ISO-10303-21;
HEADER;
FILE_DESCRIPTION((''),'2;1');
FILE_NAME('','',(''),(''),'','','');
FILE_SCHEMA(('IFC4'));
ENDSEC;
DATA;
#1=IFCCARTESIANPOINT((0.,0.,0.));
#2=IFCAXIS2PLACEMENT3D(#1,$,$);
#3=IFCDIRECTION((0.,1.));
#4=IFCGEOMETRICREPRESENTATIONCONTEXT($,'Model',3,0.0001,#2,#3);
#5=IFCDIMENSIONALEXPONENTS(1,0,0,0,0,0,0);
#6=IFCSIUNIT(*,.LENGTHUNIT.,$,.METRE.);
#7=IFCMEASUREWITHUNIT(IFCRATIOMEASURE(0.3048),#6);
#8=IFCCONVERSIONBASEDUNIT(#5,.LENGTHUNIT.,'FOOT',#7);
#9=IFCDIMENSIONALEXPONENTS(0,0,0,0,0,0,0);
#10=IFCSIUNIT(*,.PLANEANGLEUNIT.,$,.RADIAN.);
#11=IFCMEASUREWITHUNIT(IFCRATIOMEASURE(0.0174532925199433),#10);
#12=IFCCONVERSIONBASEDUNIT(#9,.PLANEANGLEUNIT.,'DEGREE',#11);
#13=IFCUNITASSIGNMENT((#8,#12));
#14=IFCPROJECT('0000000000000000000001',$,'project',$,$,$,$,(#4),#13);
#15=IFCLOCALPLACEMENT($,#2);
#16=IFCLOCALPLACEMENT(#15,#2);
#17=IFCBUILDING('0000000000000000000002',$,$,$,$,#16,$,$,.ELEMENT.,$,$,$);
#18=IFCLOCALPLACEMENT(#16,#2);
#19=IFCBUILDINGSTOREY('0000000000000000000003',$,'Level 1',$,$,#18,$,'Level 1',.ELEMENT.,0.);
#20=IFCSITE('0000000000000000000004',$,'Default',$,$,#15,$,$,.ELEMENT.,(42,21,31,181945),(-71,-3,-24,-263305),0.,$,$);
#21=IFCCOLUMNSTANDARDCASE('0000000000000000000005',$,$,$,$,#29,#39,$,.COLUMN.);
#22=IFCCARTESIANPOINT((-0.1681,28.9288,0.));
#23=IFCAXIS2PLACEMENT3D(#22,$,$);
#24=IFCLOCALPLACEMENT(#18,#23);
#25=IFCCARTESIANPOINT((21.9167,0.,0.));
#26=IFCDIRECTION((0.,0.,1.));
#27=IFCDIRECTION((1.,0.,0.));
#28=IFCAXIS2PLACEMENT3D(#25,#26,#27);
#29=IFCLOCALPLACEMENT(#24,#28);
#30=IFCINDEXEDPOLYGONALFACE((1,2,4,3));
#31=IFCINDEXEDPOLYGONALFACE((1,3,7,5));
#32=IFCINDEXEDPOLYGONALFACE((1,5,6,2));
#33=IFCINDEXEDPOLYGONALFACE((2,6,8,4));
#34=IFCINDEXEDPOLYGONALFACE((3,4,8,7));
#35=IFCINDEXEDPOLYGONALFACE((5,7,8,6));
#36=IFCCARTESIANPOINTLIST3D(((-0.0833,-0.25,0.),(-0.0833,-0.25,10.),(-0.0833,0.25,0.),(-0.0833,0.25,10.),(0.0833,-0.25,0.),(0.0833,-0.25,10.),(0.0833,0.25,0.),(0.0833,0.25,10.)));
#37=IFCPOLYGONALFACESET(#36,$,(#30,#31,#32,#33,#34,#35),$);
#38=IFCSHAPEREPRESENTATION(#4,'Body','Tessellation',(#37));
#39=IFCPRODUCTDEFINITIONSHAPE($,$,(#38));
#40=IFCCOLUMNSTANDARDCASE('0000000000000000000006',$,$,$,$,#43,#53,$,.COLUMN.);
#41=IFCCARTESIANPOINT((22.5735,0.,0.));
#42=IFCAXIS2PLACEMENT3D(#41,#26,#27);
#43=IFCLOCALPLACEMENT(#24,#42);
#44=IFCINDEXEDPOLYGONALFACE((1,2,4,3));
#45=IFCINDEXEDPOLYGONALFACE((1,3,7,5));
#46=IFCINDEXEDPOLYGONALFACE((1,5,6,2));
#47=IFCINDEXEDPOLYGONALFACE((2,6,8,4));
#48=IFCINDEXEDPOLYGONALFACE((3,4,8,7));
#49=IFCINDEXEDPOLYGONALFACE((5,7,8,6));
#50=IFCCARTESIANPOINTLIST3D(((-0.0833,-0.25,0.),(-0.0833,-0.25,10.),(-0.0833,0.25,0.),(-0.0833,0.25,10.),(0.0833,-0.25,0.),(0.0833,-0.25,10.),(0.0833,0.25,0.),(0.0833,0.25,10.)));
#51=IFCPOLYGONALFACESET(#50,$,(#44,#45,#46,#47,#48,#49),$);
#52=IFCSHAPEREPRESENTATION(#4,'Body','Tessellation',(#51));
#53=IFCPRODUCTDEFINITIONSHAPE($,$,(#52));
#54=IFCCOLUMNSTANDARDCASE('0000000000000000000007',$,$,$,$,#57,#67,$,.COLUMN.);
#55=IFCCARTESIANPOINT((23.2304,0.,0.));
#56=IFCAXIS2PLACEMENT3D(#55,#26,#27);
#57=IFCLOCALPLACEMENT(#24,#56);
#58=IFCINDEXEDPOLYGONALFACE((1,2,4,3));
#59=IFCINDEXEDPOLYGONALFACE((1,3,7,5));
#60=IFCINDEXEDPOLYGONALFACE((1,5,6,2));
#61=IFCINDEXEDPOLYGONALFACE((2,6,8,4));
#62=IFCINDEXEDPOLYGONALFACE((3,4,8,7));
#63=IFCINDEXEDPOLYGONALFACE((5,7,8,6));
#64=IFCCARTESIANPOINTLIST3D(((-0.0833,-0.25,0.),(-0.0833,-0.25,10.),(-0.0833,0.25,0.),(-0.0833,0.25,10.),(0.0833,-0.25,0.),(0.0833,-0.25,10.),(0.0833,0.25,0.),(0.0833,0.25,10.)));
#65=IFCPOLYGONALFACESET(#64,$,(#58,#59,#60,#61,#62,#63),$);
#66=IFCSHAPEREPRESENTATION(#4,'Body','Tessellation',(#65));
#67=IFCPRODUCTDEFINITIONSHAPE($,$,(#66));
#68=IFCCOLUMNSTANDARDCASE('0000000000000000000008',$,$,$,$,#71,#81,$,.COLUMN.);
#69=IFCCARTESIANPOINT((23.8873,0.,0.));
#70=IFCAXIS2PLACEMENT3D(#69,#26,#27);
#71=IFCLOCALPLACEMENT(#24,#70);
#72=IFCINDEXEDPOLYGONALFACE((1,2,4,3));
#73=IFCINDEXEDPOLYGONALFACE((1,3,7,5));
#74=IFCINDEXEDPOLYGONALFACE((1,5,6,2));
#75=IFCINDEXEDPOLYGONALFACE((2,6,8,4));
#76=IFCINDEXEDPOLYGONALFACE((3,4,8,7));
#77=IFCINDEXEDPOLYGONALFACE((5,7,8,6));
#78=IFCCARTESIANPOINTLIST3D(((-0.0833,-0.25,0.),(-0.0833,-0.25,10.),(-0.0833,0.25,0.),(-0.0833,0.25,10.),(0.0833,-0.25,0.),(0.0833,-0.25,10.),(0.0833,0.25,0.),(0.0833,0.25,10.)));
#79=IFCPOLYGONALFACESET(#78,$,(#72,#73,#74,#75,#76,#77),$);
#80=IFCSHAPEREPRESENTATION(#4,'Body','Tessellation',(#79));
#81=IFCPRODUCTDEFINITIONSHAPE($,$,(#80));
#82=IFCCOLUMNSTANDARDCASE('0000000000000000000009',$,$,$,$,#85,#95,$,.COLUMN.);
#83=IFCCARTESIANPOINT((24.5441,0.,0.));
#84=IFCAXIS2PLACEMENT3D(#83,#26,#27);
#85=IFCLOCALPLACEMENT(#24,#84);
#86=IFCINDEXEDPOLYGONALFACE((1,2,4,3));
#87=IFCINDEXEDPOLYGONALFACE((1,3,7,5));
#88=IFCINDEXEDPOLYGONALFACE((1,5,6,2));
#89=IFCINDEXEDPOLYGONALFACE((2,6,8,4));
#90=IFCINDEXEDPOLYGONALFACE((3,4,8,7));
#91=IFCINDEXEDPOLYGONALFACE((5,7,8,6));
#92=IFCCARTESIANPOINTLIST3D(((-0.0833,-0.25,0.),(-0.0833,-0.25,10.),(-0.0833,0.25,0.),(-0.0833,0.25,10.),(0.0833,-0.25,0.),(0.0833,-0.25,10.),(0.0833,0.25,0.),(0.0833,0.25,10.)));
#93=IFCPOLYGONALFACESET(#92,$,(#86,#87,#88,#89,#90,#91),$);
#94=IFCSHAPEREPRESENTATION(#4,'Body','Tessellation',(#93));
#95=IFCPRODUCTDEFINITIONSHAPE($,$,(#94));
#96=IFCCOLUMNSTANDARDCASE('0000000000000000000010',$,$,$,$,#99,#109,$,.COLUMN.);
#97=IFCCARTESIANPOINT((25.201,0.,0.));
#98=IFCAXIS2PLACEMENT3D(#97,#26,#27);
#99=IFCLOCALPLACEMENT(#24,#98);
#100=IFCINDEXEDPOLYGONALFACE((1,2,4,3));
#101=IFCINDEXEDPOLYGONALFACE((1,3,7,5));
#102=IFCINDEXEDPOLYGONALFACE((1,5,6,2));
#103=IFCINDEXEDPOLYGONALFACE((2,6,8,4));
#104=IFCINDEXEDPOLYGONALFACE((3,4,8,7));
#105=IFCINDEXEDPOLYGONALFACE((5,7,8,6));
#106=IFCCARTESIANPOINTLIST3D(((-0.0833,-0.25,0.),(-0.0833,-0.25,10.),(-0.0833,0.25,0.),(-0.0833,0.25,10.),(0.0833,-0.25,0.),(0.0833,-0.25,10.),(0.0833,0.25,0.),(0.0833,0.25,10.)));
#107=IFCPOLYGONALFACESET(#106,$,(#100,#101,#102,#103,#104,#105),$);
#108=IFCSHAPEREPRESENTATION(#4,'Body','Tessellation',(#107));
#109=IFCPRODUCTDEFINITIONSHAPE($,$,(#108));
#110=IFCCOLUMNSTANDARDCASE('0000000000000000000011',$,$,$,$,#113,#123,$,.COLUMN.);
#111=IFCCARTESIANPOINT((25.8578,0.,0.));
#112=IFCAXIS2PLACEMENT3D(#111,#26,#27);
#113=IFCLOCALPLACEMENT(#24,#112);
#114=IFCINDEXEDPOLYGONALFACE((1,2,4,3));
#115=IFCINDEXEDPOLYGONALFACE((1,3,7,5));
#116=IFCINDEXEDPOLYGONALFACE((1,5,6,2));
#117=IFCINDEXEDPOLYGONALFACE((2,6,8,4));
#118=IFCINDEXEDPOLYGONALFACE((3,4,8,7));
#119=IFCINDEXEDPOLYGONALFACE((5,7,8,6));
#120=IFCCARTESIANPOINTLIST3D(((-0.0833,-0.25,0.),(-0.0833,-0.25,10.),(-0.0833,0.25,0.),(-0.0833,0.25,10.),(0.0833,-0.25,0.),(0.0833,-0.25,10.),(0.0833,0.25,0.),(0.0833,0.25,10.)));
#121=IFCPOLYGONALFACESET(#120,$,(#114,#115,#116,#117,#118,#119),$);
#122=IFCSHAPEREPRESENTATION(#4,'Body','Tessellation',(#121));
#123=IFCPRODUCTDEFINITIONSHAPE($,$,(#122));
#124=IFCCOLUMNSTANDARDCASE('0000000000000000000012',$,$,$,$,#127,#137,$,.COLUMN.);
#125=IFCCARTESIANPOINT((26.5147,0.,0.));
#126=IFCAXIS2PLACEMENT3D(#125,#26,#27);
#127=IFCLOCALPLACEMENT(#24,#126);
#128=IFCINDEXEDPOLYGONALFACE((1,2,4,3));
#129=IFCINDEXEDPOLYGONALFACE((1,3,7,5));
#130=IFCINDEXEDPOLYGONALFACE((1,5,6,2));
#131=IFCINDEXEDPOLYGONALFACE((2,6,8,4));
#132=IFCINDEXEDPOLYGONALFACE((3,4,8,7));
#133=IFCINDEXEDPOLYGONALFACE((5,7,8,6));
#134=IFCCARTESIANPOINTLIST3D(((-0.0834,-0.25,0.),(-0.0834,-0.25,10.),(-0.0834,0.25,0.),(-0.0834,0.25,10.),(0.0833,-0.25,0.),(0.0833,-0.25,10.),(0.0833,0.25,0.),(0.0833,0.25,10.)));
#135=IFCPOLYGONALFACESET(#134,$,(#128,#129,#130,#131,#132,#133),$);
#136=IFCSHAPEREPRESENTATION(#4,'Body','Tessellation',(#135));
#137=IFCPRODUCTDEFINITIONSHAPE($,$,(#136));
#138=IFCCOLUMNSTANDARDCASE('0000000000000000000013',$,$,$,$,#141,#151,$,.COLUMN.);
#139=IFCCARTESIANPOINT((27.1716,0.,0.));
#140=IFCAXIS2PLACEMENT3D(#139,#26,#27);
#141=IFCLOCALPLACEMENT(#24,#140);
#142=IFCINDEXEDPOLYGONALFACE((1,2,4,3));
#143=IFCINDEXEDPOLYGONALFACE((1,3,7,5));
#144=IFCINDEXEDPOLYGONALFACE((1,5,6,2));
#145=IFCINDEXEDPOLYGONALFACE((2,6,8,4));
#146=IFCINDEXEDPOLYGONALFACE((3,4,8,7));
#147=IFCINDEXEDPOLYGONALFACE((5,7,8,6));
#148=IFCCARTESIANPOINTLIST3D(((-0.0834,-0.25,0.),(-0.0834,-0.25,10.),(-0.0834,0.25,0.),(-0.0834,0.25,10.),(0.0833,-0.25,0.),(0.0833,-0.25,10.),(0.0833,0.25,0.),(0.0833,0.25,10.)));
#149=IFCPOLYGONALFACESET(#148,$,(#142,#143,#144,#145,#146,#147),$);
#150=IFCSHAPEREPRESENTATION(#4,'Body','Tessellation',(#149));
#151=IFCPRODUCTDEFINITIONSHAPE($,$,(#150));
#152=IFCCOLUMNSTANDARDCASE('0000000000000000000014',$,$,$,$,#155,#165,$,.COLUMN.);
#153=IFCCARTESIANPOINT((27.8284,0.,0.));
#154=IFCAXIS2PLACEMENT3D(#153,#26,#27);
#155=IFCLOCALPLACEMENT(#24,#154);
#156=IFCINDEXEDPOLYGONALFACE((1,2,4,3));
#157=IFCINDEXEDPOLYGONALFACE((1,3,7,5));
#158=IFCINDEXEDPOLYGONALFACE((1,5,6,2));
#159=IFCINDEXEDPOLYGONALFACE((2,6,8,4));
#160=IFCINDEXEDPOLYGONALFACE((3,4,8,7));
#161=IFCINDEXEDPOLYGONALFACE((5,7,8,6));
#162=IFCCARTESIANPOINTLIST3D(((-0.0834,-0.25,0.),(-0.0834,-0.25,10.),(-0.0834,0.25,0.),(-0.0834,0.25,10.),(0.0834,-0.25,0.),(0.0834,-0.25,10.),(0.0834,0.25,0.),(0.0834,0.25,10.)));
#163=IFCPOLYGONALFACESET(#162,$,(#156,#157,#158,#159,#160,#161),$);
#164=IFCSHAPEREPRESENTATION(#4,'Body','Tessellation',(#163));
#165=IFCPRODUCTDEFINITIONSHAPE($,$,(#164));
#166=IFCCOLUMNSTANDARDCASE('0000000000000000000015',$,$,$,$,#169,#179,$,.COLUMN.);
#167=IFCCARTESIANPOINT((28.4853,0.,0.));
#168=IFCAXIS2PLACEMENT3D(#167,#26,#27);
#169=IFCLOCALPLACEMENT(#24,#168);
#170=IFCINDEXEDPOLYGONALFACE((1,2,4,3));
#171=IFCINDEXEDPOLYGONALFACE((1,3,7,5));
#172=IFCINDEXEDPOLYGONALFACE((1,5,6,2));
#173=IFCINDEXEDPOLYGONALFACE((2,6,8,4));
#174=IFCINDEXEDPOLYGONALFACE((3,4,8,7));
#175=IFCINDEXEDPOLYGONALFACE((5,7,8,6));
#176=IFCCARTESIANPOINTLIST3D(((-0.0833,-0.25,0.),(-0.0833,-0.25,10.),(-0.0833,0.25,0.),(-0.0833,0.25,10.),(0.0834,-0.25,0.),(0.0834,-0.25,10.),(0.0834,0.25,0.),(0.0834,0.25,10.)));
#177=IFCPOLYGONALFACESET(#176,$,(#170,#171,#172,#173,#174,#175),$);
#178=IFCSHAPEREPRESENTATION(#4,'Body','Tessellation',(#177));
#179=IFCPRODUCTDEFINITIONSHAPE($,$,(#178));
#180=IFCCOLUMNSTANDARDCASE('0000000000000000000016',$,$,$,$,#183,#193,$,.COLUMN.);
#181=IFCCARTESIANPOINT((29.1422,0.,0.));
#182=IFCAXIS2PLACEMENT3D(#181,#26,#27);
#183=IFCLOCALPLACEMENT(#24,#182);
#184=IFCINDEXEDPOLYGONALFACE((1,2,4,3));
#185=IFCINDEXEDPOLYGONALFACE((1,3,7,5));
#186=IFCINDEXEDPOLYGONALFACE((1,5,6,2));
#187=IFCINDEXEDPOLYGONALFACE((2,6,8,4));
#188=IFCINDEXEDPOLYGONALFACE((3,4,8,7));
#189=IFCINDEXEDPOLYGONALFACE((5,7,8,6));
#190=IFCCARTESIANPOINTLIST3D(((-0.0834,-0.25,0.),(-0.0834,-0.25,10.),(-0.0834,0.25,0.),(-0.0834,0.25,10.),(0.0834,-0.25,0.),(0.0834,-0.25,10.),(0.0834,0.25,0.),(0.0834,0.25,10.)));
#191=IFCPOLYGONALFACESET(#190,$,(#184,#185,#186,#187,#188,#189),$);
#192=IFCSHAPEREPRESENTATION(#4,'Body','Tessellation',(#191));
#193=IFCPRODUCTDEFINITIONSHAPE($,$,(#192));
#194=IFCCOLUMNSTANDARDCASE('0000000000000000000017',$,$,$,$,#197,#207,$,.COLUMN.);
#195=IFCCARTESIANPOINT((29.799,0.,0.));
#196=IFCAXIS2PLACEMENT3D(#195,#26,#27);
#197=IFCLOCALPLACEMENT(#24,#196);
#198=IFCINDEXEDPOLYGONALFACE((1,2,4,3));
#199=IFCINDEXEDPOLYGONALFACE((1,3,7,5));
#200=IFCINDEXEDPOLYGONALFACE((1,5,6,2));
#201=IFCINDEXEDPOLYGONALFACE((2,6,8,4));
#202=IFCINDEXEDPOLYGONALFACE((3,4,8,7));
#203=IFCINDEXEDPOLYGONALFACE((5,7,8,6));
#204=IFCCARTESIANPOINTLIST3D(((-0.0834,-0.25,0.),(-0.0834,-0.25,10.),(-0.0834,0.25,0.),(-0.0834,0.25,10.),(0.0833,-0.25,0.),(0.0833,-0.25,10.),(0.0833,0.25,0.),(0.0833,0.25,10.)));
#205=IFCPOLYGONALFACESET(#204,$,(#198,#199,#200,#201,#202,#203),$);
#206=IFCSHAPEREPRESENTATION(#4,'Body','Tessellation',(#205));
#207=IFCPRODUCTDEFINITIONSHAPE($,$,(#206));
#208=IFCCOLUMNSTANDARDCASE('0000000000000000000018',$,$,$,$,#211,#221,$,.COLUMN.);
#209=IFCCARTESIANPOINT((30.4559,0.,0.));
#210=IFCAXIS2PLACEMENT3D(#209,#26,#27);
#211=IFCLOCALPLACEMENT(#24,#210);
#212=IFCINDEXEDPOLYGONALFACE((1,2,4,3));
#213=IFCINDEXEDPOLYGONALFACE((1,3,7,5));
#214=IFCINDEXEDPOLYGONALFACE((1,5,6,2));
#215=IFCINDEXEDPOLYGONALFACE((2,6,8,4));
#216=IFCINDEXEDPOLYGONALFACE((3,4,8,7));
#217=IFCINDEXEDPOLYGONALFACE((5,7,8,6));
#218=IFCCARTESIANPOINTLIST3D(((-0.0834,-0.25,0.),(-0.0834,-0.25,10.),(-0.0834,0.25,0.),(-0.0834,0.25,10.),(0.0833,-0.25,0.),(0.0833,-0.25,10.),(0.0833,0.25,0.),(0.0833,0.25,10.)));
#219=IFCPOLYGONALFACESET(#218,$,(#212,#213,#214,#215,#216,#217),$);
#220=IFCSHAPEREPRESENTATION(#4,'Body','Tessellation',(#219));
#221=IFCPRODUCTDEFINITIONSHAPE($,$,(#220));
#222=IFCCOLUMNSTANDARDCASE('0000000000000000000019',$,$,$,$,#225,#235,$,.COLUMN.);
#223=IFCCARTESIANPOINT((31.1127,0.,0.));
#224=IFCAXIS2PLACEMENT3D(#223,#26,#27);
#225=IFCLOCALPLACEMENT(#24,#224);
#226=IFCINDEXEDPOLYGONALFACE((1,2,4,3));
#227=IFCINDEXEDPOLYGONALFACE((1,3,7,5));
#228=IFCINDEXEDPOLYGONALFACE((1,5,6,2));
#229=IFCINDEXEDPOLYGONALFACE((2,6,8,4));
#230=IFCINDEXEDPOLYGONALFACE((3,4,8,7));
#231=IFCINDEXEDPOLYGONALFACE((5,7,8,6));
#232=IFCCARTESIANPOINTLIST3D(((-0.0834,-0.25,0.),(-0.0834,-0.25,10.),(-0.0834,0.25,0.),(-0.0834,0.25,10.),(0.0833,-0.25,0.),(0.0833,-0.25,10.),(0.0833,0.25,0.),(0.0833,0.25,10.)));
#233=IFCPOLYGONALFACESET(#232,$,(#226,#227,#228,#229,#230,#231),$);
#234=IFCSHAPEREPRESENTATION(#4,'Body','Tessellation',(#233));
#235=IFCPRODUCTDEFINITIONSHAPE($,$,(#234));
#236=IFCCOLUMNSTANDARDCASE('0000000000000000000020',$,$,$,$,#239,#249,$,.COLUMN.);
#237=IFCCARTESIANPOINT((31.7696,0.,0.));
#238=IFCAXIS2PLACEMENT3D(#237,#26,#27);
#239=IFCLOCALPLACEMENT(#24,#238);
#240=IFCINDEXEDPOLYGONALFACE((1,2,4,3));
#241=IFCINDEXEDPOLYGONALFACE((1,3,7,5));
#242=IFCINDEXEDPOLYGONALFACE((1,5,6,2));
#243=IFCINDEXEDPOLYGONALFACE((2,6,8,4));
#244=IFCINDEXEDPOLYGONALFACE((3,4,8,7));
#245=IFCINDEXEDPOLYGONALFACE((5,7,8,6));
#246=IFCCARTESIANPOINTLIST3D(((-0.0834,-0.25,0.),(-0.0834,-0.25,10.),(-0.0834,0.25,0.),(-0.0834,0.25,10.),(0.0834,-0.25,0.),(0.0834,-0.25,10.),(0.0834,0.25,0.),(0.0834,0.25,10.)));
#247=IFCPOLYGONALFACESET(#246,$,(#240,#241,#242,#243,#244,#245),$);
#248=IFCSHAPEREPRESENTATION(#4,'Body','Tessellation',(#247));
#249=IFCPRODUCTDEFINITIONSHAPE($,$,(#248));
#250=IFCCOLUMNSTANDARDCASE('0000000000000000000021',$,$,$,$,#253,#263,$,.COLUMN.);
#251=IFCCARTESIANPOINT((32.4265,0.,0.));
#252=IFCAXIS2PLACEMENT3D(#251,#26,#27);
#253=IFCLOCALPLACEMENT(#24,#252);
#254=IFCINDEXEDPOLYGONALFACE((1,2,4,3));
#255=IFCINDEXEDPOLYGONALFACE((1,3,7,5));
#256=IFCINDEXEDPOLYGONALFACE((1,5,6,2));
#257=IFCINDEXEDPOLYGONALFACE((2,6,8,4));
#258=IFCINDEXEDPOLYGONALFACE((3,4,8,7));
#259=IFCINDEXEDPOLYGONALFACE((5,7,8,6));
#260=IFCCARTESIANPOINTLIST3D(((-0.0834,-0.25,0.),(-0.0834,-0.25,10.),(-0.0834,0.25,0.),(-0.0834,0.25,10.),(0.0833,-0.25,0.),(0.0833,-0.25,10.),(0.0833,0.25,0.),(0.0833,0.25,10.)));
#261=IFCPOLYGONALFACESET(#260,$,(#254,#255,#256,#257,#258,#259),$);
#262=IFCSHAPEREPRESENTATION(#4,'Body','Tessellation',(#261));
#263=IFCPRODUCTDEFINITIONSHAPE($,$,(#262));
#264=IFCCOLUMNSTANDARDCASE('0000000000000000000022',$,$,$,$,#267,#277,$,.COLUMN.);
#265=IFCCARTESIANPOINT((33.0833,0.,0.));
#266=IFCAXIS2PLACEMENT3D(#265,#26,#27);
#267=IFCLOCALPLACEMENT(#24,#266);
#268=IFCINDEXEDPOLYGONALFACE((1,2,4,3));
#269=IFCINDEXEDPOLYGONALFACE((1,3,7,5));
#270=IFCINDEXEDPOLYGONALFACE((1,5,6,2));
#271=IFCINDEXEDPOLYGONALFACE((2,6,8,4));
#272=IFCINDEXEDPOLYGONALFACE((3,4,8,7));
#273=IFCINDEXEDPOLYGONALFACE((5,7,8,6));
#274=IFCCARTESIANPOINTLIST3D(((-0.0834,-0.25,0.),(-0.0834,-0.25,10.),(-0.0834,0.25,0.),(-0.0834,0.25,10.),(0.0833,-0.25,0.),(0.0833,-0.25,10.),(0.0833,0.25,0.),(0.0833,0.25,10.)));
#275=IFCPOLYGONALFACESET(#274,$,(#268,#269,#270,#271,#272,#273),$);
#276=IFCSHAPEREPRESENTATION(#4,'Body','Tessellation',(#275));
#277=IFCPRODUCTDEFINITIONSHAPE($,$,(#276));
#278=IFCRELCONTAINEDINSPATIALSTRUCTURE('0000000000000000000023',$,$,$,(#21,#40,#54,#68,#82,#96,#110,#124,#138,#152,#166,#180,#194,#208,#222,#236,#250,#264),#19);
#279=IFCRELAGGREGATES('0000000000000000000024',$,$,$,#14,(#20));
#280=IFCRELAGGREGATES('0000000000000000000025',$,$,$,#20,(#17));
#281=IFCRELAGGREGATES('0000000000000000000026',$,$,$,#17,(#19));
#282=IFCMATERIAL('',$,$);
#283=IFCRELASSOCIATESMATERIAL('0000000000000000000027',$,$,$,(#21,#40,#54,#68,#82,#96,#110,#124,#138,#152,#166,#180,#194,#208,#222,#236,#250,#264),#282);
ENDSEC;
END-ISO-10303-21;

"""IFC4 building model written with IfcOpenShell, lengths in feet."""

from ifc_helpers import new_model, entity, si_unit, converted_unit, direction, frame, origin, place, context, project, spatial, rectangle, extrude, material, element, save


model = new_model("IFC4")

# Units and contexts
model_context = context("Model", 3, precision=0.0001, world=origin(), true_north=direction((0.0, 1.0)))
ifc_project = project(units=[converted_unit("LENGTHUNIT", "FOOT", entity("IfcRatioMeasure", 0.3048), si_unit("LENGTHUNIT", "METRE"), dimensions=[1, 0, 0, 0, 0, 0, 0]), converted_unit("PLANEANGLEUNIT", "DEGREE", entity("IfcRatioMeasure", 0.0174532925199433), si_unit("PLANEANGLEUNIT", "RADIAN"), dimensions=[0, 0, 0, 0, 0, 0, 0])], contexts=[model_context])

# Site, building, storey
site_placement = place(None, origin())
site = spatial("IfcSite", under=ifc_project, at=site_placement, Name="Default", CompositionType="ELEMENT", RefLatitude=(42, 21, 31, 181945), RefLongitude=(-71, -3, -24, -263305), RefElevation=0.0)
building_placement = place(site_placement, origin())
building = spatial("IfcBuilding", under=site, at=building_placement, CompositionType="ELEMENT")
storey_placement = place(building_placement, origin())
storey = spatial("IfcBuildingStorey", under=building, at=storey_placement, Name="Level 1", LongName="Level 1", CompositionType="ELEMENT", Elevation=0.0)

# Columns
ifc_material_1 = material(Name="")
placement = place(storey_placement, frame((-0.1681, 28.9288, 0.0)))
for number, where, z_axis, x_axis in (
    (1, (21.9167, 0.0, 0.0), (0.0, 0.0, 1.0), (1.0, 0.0, 0.0)),
    (2, (22.5735, 0.0, 0.0), (0.0, 0.0, 1.0), (1.0, 0.0, 0.0)),
    (3, (23.2304, 0.0, 0.0), (0.0, 0.0, 1.0), (1.0, 0.0, 0.0)),
    (4, (23.8873, 0.0, 0.0), (0.0, 0.0, 1.0), (1.0, 0.0, 0.0)),
    (5, (24.5441, 0.0, 0.0), (0.0, 0.0, 1.0), (1.0, 0.0, 0.0)),
    (6, (25.201, 0.0, 0.0), (0.0, 0.0, 1.0), (1.0, 0.0, 0.0)),
    (7, (25.8578, 0.0, 0.0), (0.0, 0.0, 1.0), (1.0, 0.0, 0.0)),
    (8, (26.5147, 0.0, 0.0), (0.0, 0.0, 1.0), (1.0, 0.0, 0.0)),
    (9, (27.1716, 0.0, 0.0), (0.0, 0.0, 1.0), (1.0, 0.0, 0.0)),
    (10, (27.8284, 0.0, 0.0), (0.0, 0.0, 1.0), (1.0, 0.0, 0.0)),
    (11, (28.4853, 0.0, 0.0), (0.0, 0.0, 1.0), (1.0, 0.0, 0.0)),
    (12, (29.1422, 0.0, 0.0), (0.0, 0.0, 1.0), (1.0, 0.0, 0.0)),
    (13, (29.799, 0.0, 0.0), (0.0, 0.0, 1.0), (1.0, 0.0, 0.0)),
    (14, (30.4559, 0.0, 0.0), (0.0, 0.0, 1.0), (1.0, 0.0, 0.0)),
    (15, (31.1127, 0.0, 0.0), (0.0, 0.0, 1.0), (1.0, 0.0, 0.0)),
    (16, (31.7696, 0.0, 0.0), (0.0, 0.0, 1.0), (1.0, 0.0, 0.0)),
    (17, (32.4265, 0.0, 0.0), (0.0, 0.0, 1.0), (1.0, 0.0, 0.0)),
    (18, (33.0833, 0.0, 0.0), (0.0, 0.0, 1.0), (1.0, 0.0, 0.0)),
):
    element("IfcColumnStandardCase", number, at=place(placement, frame(where, z_axis=z_axis, x_axis=x_axis)), inside=storey, material=ifc_material_1, PredefinedType="COLUMN", context=model_context, shape_type="SweptSolid", body=[
        extrude(rectangle(XDim=0.1667, YDim=0.5), origin(), (0.0, 0.0, 1.0), 10.0),
    ])

save(model, "model.ifc")
